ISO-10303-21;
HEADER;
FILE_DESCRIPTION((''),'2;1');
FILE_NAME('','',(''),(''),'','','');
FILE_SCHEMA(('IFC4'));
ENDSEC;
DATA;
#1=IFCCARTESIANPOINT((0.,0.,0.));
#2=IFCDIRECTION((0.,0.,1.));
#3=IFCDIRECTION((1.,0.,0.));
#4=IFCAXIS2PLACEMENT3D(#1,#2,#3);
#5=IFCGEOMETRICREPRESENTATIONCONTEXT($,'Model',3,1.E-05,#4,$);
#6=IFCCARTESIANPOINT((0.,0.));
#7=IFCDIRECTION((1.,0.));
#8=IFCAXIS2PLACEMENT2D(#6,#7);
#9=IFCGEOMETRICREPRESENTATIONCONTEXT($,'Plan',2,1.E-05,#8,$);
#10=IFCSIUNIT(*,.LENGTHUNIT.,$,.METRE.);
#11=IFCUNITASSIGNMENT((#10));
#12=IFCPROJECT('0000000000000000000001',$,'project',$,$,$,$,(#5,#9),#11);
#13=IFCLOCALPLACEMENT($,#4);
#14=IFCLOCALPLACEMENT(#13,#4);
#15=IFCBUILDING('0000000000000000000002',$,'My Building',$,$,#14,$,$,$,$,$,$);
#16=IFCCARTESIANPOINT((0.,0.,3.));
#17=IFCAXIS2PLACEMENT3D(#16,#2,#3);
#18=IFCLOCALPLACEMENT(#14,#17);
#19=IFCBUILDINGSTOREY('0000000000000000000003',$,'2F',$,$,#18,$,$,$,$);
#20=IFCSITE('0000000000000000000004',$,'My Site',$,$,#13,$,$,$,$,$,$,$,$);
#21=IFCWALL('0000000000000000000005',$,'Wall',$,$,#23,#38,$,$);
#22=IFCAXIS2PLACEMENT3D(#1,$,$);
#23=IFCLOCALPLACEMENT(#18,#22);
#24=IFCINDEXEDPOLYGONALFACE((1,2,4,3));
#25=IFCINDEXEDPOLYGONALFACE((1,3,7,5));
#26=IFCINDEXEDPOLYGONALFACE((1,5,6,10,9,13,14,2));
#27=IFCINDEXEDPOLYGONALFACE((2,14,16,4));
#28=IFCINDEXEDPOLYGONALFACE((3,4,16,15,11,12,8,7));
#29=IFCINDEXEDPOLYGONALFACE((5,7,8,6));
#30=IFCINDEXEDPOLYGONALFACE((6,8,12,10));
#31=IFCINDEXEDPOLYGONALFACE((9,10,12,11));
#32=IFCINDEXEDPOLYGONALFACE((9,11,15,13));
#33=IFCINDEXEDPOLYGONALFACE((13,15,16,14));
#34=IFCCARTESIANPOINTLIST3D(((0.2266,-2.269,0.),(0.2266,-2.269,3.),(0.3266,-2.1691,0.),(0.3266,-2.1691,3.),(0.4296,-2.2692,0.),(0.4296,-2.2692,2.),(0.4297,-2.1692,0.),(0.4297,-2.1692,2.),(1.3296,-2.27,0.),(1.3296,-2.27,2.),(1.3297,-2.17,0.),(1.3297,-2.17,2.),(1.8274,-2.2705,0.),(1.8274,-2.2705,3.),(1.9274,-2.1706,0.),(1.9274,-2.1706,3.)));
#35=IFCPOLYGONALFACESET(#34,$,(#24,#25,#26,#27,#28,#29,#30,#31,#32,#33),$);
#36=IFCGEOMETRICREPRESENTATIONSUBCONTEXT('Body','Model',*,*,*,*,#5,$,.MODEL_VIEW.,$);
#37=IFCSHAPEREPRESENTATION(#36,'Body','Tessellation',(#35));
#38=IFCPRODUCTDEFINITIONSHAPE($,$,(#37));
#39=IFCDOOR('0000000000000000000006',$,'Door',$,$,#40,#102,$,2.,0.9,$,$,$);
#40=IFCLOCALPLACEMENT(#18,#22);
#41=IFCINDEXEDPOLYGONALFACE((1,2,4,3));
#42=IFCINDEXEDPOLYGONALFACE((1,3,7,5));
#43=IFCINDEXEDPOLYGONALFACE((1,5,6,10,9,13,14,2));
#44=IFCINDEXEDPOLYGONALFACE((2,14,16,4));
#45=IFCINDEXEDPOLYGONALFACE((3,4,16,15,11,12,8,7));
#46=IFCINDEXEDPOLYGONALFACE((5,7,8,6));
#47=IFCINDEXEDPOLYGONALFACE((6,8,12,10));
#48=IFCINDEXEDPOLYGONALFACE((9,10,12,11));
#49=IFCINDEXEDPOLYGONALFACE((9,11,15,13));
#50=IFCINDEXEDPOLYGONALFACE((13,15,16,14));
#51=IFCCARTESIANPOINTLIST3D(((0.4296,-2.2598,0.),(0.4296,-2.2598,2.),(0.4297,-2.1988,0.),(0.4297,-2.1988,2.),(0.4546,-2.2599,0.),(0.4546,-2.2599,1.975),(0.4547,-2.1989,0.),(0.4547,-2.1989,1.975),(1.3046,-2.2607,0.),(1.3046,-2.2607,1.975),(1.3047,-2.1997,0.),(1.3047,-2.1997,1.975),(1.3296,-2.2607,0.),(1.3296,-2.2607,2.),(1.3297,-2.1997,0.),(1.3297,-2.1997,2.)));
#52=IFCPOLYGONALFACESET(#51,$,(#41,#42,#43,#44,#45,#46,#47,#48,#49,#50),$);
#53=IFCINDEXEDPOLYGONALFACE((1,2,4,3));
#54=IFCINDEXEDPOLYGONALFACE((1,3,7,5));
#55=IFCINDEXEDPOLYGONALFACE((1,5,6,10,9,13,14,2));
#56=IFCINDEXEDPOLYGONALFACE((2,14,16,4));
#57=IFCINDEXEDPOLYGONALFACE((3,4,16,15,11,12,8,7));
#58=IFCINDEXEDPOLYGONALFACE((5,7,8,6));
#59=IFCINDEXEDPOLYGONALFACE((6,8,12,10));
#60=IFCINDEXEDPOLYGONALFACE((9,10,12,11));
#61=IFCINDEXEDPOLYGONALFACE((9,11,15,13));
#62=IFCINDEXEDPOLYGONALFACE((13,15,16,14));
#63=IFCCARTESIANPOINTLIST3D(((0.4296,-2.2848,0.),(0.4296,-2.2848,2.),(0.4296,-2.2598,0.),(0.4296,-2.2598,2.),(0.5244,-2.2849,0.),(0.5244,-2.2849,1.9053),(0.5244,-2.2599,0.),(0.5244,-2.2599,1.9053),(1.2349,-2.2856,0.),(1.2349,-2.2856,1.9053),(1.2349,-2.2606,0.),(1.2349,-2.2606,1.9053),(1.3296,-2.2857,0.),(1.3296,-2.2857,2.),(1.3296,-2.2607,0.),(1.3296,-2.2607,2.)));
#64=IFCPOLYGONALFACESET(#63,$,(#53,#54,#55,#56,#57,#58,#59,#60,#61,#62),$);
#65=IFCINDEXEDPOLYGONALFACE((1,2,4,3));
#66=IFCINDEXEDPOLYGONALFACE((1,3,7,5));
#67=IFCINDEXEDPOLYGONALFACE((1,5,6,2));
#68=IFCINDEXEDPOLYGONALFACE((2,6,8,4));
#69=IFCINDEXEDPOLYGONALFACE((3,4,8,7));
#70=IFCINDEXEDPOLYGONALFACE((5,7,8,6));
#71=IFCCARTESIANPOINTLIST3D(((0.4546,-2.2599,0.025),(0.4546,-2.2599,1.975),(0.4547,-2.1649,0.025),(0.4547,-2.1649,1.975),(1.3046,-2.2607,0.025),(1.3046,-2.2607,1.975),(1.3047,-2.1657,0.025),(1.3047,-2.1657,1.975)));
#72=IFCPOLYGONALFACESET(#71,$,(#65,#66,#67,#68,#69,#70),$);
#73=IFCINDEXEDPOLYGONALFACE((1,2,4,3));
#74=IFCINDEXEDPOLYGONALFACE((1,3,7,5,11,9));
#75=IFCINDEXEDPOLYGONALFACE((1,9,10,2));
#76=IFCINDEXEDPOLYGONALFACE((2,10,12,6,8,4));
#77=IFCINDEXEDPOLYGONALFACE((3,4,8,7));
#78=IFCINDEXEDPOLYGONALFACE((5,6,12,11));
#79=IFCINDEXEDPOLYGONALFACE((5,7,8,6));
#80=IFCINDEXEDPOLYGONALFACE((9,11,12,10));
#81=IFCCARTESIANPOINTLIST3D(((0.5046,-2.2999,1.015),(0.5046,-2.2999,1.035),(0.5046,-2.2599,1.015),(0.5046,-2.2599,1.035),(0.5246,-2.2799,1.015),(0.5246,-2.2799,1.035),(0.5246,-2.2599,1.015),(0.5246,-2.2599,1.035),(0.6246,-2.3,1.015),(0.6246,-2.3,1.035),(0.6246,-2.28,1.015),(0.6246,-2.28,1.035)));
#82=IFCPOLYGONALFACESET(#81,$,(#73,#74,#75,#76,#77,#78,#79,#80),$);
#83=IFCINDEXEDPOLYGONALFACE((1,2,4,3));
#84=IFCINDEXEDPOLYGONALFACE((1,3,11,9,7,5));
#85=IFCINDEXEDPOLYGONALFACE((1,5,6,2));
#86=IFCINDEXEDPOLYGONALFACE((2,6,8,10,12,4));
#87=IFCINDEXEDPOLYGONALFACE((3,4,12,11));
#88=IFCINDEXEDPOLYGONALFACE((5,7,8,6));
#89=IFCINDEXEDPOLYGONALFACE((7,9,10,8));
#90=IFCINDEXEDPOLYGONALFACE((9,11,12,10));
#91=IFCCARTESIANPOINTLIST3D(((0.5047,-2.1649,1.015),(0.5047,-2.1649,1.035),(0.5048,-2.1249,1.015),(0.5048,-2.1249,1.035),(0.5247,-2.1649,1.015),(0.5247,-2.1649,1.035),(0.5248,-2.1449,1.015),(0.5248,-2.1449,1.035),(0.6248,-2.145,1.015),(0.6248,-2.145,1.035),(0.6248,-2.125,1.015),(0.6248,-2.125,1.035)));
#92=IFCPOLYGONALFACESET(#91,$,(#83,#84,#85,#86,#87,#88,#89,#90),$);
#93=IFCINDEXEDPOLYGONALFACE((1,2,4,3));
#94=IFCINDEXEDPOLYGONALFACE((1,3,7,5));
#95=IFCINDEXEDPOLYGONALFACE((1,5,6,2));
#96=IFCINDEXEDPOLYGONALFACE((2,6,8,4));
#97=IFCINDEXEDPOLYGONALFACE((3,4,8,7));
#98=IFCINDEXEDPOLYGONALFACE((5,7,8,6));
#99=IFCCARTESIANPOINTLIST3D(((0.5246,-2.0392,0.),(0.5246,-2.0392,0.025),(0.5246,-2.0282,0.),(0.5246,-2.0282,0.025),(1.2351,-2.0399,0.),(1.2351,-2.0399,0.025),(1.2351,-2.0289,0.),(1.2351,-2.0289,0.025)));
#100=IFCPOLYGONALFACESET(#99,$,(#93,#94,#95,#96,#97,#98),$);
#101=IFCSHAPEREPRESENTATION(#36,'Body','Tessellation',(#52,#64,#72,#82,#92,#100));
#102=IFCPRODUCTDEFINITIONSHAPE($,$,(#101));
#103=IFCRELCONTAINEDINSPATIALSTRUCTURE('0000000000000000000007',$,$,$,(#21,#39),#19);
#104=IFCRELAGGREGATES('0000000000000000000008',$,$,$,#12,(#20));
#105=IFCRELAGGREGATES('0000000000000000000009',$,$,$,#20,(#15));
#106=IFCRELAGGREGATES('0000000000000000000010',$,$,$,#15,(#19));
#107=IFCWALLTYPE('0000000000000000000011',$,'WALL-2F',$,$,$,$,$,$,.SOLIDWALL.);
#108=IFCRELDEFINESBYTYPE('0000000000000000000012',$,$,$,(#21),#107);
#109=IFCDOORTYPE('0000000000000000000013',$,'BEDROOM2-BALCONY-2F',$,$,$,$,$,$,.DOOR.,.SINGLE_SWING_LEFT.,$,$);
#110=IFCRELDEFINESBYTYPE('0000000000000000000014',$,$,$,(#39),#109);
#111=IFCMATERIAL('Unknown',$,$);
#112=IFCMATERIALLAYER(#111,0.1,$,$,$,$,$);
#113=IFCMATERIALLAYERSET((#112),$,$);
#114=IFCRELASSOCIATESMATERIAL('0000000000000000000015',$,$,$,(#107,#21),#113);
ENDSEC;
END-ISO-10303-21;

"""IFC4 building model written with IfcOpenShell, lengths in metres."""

from ifc_helpers import new_model, entity, si_unit, frame, origin_with_axes, origin_2d_with_axis, place, context, subcontext, project, spatial, line, indexed_curve, outline, extrude, shape, source, transform, mapped, material, layer, layer_set, layer_usage, type_object, type_shapes, element, fill, save


model = new_model("IFC4")

# Units and contexts
model_context = context("Model", 3, precision=1e-05, world=origin_with_axes())
plan_context = context("Plan", 2, precision=1e-05, world=origin_2d_with_axis())
body_context_1 = subcontext(model_context, "Body", "Model", "MODEL_VIEW")
body_context_2 = subcontext(plan_context, "Body", "Plan", "PLAN_VIEW")
ifc_project = project(units=[si_unit("LENGTHUNIT", "METRE")], contexts=[model_context, plan_context])

# Site, building, storey
site_placement = place(None, origin_with_axes())
site = spatial("IfcSite", under=ifc_project, at=site_placement, Name="My Site")
building_placement = place(site_placement, origin_with_axes())
building = spatial("IfcBuilding", under=site, at=building_placement, Name="My Building")
storey_placement = place(building_placement, frame((0.0, 0.0, 3.0), z_axis=(0.0, 0.0, 1.0), x_axis=(1.0, 0.0, 0.0)))
storey = spatial("IfcBuildingStorey", under=building, at=storey_placement, Name="2F")

# Shared definitions
ifc_material = material(Name="Unknown")

# Shared definitions
ifc_layer_1 = layer(ifc_material, 0.1)
ifc_layer_set_1 = layer_set([ifc_layer_1])
wall_type = type_object("IfcWallType", Name="WALL-2F", PredefinedType="SOLIDWALL", material=ifc_layer_set_1)

# Wall, opening, door
ifc_layer_usage_1 = layer_usage(ifc_layer_set_1, "AXIS2", "POSITIVE", 0.0)
wall_1_placement = place(storey_placement, frame((1.9274, -2.1706, 0.0), z_axis=(0.0, 0.0, 1.0), x_axis=(-1.0, 0.000946, 0.0)))
wall_1 = element("IfcWall", 1, at=wall_1_placement, inside=storey, type_object=wall_type, material=ifc_layer_usage_1, Name="Wall", context=body_context_1, shape_type="SweptSolid", body=[
    extrude(outline(indexed_curve([(0.0, 0.0), (0.1, 0.1), (1.7007, 0.1), (1.6008, 0.0)], segments=[line(1, 2, 3, 4, 1)])), origin_with_axes(), (0.0, 0.0, 1.0), 3.0),
])
shared_shape_1 = source(origin_with_axes(), body_context_1, "Body", "SweptSolid", [
    extrude(outline(indexed_curve([(0.0, 0.0), (0.9, 0.0), (0.9, 2.0), (0.0, 2.0)], segments=[line(1, 2, 3, 4, 1)])), frame((0.0, -0.6, 0.0), z_axis=(0.0, -1.0, 0.0), x_axis=(1.0, 0.0, 0.0)), (0.0, 0.0, -1.0), 1.2),
])
opening_1_placement = place(wall_1_placement, frame((1.4977, 0.1, 0.0), z_axis=(0.0, 0.0, 1.0), x_axis=(-1.0, 0.0, 0.0)))
opening_1 = element("IfcOpeningElement", 2, at=opening_1_placement, cuts=wall_1, PredefinedType="OPENING", context=body_context_1, shape_type="MappedRepresentation", body=[
    mapped(shared_shape_1, transform((0.0, 0.0, 0.0), x_axis=(1.0, 0.0, 0.0), y_axis=(0.0, 1.0, 0.0), z_axis=(0.0, 0.0, 1.0), scale=1.0)),
])
door_type_1 = type_object("IfcDoorType", Name="BEDROOM2-BALCONY-2F", OperationType="SINGLE_SWING_LEFT", PredefinedType="DOOR")
shared_shape_2 = source(origin_with_axes(), body_context_1, "Body", "SweptSolid", [
    extrude(outline(indexed_curve([(0.0, 0.0), (0.0, 2.0), (0.9, 2.0), (0.9, 0.0), (0.875, 0.0), (0.875, 1.975), (0.025, 1.975), (0.025, 0.0)], segments=[line(1, 2, 3, 4, 5, 6, 7, 8, 1)])), frame((0.0, 0.0093, 0.0), z_axis=(0.0, -1.0, 0.0), x_axis=(1.0, 0.0, 0.0)), (0.0, 0.0, -1.0), 0.061),
    extrude(outline(indexed_curve([(0.0, 0.0), (0.0, 2.0), (0.9, 2.0), (0.9, 0.0), (0.8053, 0.0), (0.8053, 1.9053), (0.0947, 1.9053), (0.0947, 0.0)], segments=[line(1, 2, 3, 4, 5, 6, 7, 8, 1)])), frame((0.0, -0.0157, 0.0), z_axis=(0.0, -1.0, 0.0), x_axis=(1.0, 0.0, 0.0)), (0.0, 0.0, -1.0), 0.025),
    extrude(outline(indexed_curve([(0.0, 0.0), (0.85, 0.0), (0.85, 0.095), (0.0, 0.095)], segments=[line(1, 2, 3, 4, 1)])), frame((0.025, 0.0093, 0.025), z_axis=(0.0, 0.0, 1.0), x_axis=(1.0, 0.0, 0.0)), (0.0, 0.0, 1.0), 1.95),
    extrude(outline(indexed_curve([(0.0, 0.0), (0.0, -0.04), (0.12, -0.04), (0.12, -0.02), (0.02, -0.02), (0.02, 0.0)], segments=[line(1, 2, 3, 4, 5, 6, 1)])), frame((0.075, 0.0093, 1.015), z_axis=(0.0, 0.0, 1.0), x_axis=(1.0, 0.0, 0.0)), (0.0, 0.0, 1.0), 0.02),
    extrude(outline(indexed_curve([(0.0, 0.0), (0.0, 0.04), (0.12, 0.04), (0.12, 0.02), (0.02, 0.02), (0.02, 0.0)], segments=[line(1, 2, 3, 4, 5, 6, 1)])), frame((0.075, 0.1043, 1.015), z_axis=(0.0, 0.0, 1.0), x_axis=(1.0, 0.0, 0.0)), (0.0, 0.0, 1.0), 0.02),
    extrude(outline(indexed_curve([(0.0, 0.0), (0.7105, 0.0), (0.7105, 0.011), (0.0, 0.011)], segments=[line(1, 2, 3, 4, 1)])), frame((0.0947, 0.23, 0.0), z_axis=(0.0, 0.0, 1.0), x_axis=(1.0, 0.0, 0.0)), (0.0, 0.0, 1.0), 0.025),
])
shared_shape_3 = source(origin_with_axes(), body_context_2, "Body", "Curve2D", [
    entity("IfcIndexedPolyCurve", entity("IfcCartesianPointList2D", [[0.0, -0.0157], [0.0, 0.0703], [0.025, 0.0703], [0.025, 0.0093], [0.0947, 0.0093], [0.0947, -0.0157]]), [entity("IfcLineIndex", [1, 2, 3, 4, 5, 6, 1])]),
    entity("IfcIndexedPolyCurve", entity("IfcCartesianPointList2D", [[0.9, -0.0157], [0.9, 0.0703], [0.875, 0.0703], [0.875, 0.0093], [0.8053, 0.0093], [0.8053, -0.0157]]), [entity("IfcLineIndex", [1, 2, 3, 4, 5, 6, 1])]),
    entity("IfcTrimmedCurve", entity("IfcEllipse", entity("IfcAxis2Placement2D", entity("IfcCartesianPoint", [0.78, 0.0703]), entity("IfcDirection", [1.0, 0.0])), 0.755, 0.85), [entity("IfcCartesianPoint", [0.78, 0.9203])], [entity("IfcCartesianPoint", [0.025, 0.0703])], True, "CARTESIAN"),
    entity("IfcIndexedPolyCurve", entity("IfcCartesianPointList2D", [[0.875, 0.0703], [0.78, 0.0703], [0.78, 0.9203], [0.875, 0.9203]]), [entity("IfcLineIndex", [1, 2, 3, 4, 1])]),
])
type_shapes(door_type_1, [shared_shape_2, shared_shape_3])
door_1_placement = place(opening_1_placement, frame((0.0, 0.0, 0.0), z_axis=(0.0, 0.0, 1.0), x_axis=(1.0, 0.0, 0.0)))
door_1 = element("IfcDoor", 3, at=door_1_placement, inside=storey, type_object=door_type_1, Name="Door", OverallHeight=2.0, OverallWidth=0.9, shapes=[
    shape(body_context_1, "Body", "MappedRepresentation", [mapped(shared_shape_2, transform((0.0, 0.0, 0.0), x_axis=(1.0, 0.0, 0.0), y_axis=(0.0, 1.0, 0.0), z_axis=(0.0, 0.0, 1.0), scale=1.0))]),
    shape(body_context_2, "Body", "MappedRepresentation", [mapped(shared_shape_3, transform((0.0, 0.0, 0.0), x_axis=(1.0, 0.0, 0.0), y_axis=(0.0, 1.0, 0.0), z_axis=(0.0, 0.0, 1.0), scale=1.0))]),
])
fill(opening_1, door_1)

save(model, "model.ifc")
